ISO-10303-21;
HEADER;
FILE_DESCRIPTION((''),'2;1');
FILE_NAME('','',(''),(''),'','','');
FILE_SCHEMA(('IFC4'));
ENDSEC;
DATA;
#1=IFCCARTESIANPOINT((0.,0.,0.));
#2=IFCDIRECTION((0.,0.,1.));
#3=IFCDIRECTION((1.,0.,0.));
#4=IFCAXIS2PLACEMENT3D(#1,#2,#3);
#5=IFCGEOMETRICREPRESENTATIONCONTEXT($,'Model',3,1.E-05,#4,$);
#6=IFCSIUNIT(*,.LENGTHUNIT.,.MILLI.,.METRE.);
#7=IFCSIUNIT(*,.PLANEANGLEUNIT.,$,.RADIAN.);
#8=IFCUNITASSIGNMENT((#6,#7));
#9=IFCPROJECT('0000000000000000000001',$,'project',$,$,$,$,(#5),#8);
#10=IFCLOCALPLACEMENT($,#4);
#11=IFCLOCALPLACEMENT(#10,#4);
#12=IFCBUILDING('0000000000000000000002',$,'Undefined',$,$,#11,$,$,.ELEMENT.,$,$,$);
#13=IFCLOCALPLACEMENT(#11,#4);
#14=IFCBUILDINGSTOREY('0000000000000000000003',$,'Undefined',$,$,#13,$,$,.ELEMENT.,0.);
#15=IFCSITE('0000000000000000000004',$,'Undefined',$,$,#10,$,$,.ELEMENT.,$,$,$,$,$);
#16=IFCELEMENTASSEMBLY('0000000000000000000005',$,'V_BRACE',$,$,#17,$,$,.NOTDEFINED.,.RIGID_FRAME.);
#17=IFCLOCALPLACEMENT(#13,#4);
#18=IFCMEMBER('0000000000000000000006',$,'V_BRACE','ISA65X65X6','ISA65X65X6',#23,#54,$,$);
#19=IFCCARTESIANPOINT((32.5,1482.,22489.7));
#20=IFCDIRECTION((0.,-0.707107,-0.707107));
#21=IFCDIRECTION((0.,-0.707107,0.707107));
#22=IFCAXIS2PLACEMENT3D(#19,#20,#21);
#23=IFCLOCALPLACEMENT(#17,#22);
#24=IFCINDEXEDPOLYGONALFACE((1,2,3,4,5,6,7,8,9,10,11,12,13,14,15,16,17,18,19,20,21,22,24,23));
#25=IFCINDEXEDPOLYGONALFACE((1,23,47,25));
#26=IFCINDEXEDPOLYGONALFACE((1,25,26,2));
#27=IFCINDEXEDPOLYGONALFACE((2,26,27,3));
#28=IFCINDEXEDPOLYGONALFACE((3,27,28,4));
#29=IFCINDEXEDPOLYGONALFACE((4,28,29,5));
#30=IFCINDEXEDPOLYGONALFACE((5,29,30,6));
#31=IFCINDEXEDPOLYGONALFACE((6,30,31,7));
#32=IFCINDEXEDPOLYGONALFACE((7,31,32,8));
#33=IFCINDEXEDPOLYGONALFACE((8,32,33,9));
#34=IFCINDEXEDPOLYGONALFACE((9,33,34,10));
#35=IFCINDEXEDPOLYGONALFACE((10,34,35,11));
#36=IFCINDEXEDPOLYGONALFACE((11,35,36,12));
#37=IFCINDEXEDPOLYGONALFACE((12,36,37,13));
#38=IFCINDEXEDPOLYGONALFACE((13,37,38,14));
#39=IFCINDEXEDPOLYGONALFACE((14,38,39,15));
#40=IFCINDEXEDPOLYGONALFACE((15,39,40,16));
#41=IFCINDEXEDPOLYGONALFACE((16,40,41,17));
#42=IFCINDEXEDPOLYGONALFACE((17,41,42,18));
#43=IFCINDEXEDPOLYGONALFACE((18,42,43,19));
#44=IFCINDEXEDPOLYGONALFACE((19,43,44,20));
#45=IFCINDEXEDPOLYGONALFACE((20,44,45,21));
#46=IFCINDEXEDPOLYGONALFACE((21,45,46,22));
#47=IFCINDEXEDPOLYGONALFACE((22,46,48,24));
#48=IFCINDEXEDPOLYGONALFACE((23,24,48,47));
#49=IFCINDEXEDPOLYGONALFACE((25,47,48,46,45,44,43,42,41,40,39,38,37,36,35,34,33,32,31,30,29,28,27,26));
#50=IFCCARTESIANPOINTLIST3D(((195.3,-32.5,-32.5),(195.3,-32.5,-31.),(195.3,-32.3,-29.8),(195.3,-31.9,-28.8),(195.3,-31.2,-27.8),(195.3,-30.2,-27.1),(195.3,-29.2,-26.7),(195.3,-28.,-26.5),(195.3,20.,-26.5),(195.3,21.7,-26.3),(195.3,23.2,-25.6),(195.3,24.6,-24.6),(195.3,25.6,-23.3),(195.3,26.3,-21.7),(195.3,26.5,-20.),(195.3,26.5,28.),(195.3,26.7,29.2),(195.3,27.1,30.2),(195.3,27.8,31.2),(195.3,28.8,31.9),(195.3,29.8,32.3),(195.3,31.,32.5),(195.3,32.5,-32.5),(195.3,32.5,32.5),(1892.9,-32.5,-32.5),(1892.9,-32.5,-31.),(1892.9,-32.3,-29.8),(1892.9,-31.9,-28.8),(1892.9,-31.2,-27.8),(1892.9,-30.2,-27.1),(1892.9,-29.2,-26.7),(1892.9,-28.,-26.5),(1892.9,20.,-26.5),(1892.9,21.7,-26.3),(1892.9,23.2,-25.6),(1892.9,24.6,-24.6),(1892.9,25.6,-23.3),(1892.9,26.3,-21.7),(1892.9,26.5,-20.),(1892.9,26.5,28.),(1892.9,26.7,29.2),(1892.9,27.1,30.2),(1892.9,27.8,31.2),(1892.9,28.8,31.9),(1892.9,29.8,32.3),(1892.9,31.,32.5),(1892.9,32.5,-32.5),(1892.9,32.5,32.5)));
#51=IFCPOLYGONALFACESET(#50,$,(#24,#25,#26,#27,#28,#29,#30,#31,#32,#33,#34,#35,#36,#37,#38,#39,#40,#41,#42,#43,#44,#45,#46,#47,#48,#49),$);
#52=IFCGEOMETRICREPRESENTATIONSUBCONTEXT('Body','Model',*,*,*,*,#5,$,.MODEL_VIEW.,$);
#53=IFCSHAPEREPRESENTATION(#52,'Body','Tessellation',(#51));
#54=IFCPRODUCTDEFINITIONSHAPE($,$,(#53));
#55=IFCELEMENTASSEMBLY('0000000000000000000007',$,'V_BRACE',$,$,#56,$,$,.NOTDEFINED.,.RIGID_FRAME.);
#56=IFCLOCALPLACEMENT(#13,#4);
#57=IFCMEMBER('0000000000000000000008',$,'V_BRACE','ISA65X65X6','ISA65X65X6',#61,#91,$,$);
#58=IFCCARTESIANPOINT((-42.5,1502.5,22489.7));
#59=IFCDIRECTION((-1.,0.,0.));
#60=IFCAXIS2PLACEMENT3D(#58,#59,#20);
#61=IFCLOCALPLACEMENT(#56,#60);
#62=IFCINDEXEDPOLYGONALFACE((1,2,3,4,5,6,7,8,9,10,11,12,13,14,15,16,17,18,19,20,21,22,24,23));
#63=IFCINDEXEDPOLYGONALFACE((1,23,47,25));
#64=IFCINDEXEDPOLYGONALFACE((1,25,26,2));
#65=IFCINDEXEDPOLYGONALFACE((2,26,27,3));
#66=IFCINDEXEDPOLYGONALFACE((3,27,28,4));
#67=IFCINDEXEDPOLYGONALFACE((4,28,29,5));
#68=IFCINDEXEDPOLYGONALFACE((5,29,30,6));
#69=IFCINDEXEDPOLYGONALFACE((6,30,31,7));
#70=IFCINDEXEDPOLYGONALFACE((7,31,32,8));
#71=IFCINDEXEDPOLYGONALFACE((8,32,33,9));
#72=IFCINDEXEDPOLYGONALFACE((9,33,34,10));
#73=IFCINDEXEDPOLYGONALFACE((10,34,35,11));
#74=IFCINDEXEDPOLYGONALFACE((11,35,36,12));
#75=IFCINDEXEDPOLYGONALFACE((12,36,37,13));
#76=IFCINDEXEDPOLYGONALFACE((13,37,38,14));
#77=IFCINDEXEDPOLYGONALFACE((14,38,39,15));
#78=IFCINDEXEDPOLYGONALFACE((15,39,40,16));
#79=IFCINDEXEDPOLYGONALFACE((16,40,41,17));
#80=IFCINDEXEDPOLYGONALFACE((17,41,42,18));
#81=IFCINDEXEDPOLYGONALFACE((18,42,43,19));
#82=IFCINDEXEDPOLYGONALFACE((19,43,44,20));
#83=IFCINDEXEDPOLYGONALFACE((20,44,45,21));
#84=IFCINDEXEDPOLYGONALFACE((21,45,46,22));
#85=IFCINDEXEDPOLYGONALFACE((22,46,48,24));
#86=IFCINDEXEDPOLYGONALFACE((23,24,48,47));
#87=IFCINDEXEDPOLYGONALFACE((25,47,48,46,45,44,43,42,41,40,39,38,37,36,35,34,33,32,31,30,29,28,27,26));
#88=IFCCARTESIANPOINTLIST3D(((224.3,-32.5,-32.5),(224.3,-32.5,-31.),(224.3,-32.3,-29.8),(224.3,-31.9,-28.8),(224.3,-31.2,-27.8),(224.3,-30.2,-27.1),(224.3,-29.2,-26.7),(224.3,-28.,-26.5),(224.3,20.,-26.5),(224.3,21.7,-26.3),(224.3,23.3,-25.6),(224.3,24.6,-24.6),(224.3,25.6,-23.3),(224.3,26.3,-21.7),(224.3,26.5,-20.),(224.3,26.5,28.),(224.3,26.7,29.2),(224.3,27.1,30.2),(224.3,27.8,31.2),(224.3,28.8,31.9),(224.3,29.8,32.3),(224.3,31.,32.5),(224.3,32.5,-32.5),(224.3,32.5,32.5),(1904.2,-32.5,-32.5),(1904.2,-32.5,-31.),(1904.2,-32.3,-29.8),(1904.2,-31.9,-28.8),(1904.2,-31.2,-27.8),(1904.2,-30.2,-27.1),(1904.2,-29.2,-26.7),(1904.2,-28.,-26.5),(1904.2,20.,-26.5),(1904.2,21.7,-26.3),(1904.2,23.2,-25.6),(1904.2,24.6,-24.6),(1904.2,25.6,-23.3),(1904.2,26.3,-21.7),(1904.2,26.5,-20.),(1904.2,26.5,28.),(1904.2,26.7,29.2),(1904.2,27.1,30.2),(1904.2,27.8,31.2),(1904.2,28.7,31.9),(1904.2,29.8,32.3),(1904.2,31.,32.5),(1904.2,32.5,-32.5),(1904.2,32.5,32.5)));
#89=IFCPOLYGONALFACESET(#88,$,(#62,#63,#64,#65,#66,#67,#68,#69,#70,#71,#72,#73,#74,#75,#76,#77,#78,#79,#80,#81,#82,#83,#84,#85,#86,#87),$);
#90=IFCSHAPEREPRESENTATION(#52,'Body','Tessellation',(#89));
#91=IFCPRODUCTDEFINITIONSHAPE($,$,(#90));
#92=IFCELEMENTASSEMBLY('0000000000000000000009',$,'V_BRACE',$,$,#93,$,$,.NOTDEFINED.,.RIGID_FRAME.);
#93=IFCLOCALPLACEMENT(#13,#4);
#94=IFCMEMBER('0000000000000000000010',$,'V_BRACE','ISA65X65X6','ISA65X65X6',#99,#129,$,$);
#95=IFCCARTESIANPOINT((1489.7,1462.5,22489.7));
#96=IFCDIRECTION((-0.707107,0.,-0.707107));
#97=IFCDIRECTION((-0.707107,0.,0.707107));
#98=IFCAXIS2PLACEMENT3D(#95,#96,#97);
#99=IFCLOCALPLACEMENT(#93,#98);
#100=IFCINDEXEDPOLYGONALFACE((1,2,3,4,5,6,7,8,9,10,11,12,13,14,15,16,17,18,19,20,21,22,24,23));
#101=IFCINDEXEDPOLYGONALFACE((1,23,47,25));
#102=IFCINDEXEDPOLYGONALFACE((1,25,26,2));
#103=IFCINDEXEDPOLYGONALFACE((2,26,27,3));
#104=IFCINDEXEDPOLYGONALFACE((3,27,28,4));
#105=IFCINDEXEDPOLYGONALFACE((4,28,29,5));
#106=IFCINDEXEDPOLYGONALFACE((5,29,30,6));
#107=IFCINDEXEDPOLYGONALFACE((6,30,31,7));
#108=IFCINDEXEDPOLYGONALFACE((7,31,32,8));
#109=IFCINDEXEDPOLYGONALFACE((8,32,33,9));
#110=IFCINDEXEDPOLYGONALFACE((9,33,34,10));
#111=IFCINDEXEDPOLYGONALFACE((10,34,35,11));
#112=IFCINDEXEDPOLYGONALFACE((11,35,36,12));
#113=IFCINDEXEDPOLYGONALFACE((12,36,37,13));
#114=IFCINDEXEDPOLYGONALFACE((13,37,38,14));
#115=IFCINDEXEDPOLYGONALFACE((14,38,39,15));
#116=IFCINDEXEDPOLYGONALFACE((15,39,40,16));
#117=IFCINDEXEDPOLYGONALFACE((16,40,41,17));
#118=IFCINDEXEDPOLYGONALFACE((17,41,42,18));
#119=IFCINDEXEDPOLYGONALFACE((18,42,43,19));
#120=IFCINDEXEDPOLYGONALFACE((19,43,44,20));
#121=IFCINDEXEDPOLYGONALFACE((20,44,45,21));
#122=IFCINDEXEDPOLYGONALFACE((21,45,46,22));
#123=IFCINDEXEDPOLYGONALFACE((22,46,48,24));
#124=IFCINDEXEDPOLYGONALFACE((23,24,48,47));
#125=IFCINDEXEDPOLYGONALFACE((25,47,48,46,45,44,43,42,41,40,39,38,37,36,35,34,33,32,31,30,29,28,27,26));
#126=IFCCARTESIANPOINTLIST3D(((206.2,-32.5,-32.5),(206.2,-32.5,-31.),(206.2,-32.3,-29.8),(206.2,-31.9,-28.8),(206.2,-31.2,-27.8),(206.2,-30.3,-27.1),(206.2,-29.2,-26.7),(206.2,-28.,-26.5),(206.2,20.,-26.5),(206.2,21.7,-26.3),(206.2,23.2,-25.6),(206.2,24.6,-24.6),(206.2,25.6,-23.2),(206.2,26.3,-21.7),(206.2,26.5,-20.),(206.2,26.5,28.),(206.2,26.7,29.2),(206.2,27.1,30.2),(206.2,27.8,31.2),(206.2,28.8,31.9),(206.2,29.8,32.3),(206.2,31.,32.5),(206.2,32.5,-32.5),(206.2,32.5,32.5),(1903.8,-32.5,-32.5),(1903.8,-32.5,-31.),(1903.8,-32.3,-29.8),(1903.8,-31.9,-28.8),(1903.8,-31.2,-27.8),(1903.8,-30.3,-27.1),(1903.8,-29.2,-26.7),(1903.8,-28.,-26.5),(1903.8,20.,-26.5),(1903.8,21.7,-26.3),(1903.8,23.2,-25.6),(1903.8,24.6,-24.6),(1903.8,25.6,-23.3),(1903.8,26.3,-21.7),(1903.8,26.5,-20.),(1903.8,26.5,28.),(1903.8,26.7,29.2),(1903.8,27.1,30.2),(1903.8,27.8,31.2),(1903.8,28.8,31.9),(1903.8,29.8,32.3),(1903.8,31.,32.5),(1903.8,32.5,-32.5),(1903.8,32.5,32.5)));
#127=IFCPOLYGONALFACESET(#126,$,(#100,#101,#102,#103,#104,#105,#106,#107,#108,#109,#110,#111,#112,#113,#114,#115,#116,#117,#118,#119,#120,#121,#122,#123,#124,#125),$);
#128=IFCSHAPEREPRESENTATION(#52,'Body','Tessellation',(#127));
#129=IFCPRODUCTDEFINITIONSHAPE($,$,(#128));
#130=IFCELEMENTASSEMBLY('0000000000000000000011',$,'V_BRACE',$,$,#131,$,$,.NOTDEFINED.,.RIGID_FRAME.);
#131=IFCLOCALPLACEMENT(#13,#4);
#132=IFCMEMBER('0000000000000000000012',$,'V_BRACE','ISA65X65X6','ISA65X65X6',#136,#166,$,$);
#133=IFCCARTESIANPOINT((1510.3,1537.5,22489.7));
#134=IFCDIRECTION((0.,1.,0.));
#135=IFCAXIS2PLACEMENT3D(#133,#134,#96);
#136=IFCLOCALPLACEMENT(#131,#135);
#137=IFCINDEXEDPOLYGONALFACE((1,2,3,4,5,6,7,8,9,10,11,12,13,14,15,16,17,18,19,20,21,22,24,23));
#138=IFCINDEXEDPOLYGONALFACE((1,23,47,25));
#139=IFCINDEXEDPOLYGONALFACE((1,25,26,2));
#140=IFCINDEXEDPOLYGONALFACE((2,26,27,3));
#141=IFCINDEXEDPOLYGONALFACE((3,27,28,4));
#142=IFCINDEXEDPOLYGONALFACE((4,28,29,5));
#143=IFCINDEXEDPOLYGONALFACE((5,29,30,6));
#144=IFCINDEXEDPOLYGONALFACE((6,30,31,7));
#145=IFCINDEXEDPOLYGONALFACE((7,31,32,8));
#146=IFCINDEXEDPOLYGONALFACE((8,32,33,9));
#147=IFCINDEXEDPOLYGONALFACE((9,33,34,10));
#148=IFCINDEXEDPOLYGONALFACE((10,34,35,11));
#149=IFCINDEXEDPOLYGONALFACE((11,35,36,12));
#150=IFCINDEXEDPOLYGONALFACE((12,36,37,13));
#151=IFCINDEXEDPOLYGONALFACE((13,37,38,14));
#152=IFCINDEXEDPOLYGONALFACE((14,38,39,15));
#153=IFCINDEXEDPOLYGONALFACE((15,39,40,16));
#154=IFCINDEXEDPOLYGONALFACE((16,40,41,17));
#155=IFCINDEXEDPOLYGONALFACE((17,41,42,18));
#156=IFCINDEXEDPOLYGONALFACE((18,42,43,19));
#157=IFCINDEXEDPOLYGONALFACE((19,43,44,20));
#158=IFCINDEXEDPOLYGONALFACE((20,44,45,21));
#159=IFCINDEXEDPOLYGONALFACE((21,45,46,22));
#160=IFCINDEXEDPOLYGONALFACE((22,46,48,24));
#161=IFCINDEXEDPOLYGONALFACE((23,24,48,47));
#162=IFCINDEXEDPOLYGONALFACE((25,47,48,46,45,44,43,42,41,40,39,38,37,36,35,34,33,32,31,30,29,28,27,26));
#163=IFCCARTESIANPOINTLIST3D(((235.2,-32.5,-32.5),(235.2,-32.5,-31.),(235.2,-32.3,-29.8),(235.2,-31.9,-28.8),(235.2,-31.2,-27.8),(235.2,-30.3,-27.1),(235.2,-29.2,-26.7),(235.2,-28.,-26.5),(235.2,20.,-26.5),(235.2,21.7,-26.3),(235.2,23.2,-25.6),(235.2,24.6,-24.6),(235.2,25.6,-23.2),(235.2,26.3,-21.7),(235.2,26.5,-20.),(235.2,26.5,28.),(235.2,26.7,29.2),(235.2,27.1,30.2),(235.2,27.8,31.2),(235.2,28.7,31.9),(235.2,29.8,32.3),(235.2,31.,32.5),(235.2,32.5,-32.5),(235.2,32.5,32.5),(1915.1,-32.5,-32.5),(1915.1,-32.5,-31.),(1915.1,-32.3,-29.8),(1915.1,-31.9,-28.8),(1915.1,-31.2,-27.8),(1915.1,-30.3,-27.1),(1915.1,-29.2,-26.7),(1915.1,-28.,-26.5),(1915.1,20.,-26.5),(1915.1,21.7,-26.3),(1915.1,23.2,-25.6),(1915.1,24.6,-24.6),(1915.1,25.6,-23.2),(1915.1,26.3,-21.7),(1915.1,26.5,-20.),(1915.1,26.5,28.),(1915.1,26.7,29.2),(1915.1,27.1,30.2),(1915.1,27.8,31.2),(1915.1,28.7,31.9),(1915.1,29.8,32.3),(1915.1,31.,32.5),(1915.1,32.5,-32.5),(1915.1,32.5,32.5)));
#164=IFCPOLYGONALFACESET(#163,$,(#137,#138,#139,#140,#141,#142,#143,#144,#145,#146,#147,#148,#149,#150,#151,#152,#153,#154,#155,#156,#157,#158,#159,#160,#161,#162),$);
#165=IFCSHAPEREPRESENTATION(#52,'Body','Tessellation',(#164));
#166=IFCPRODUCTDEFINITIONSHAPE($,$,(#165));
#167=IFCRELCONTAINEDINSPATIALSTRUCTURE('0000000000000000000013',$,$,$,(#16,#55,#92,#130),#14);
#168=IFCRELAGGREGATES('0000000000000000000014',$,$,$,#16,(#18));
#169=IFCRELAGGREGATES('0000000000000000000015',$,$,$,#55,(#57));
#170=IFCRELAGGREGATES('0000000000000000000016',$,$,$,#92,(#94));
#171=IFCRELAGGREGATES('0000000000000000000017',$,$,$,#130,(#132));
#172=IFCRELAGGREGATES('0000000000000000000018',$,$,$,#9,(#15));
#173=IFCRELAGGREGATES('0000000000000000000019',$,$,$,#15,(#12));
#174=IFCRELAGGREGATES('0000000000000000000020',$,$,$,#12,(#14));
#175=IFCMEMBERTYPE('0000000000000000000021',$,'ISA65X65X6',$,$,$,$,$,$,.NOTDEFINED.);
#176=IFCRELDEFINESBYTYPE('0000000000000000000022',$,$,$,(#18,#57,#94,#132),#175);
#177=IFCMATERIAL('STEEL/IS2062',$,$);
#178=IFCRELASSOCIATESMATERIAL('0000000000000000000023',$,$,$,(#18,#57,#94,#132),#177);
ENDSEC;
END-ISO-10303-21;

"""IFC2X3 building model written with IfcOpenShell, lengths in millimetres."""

from ifc_helpers import new_model, si_unit, frame, origin_with_axes, origin_2d_with_axis, place, context, subcontext, project, spatial, l_section, extrude, clip, halfspace, material, type_object, element, aggregate, save


model = new_model("IFC2X3")

# Units and contexts
model_context = context("Model", 3, precision=1e-05, world=origin_with_axes())
body_context = subcontext(model_context, "Body", "Model", "MODEL_VIEW")
ifc_project = project(units=[si_unit("LENGTHUNIT", "METRE", prefix="MILLI"), si_unit("PLANEANGLEUNIT", "RADIAN")], contexts=[model_context])

# Site, building, storey
site_placement = place(None, origin_with_axes())
site = spatial("IfcSite", under=ifc_project, at=site_placement, Name="Undefined", CompositionType="ELEMENT")
building_placement = place(site_placement, origin_with_axes())
building = spatial("IfcBuilding", under=site, at=building_placement, Name="Undefined", CompositionType="ELEMENT")
storey_placement = place(building_placement, origin_with_axes())
storey = spatial("IfcBuildingStorey", under=building, at=storey_placement, Name="Undefined", CompositionType="ELEMENT", Elevation=0.0)

# Shared definitions
ifc_material = material(Name="STEEL/IS2062")

# Element assemblies, members
assembly_1_placement = place(storey_placement, origin_with_axes())
assembly_1 = element("IfcElementAssembly", 1, at=assembly_1_placement, inside=storey, Name="V_BRACE", AssemblyPlace="NOTDEFINED", PredefinedType="RIGID_FRAME")
member_type = type_object("IfcMemberType", Name="ISA65X65X6", PredefinedType="NOTDEFINED")
member_1_placement = place(assembly_1_placement, frame((32.5, 1482.0, 22489.7), z_axis=(0.0, -0.707107, -0.707107), x_axis=(0.0, -0.707107, 0.707107)))
member_1 = element("IfcMember", 2, at=member_1_placement, type_object=member_type, material=ifc_material, Name="V_BRACE", Description="ISA65X65X6", ObjectType="ISA65X65X6", context=body_context, shape_type="Clipping", body=[
    clip(clip(extrude(l_section(Depth=65.0, Width=65.0, Thickness=6.0, FilletRadius=6.5, EdgeRadius=4.5, at=origin_2d_with_axis()), frame((2121.3, 0.0, 0.0), z_axis=(-1.0, 0.0, 0.0), x_axis=(0.0, -1.0, 0.0)), (0.0, 0.0, 1.0), 2121.3), halfspace(frame((1892.9, 42.5, 0.0), z_axis=(-1.0, 0.0, 0.0), x_axis=(0.0, 0.0, 1.0)), True)), halfspace(frame((195.3, 42.5, 0.0), z_axis=(1.0, 0.0, 0.0), x_axis=(0.0, 0.0, -1.0)), True)),
])
aggregate(assembly_1, [member_1])
assembly_2_placement = place(storey_placement, origin_with_axes())
assembly_2 = element("IfcElementAssembly", 3, at=assembly_2_placement, inside=storey, Name="V_BRACE", AssemblyPlace="NOTDEFINED", PredefinedType="RIGID_FRAME")
member_2_placement = place(assembly_2_placement, frame((-42.5, 1502.5, 22489.7), z_axis=(-1.0, 0.0, 0.0), x_axis=(0.0, -0.707107, -0.707107)))
member_2 = element("IfcMember", 4, at=member_2_placement, type_object=member_type, material=ifc_material, Name="V_BRACE", Description="ISA65X65X6", ObjectType="ISA65X65X6", context=body_context, shape_type="Clipping", body=[
    clip(clip(extrude(l_section(Depth=65.0, Width=65.0, Thickness=6.0, FilletRadius=6.5, EdgeRadius=4.5, at=origin_2d_with_axis()), frame((2121.3, 0.0, 0.0), z_axis=(-1.0, 0.0, 0.0), x_axis=(0.0, -1.0, 0.0)), (0.0, 0.0, 1.0), 2121.3), halfspace(frame((1904.2, 0.0, -32.5), z_axis=(-1.0, 0.0, 0.0), x_axis=(0.0, -1.0, 0.0)), True)), halfspace(frame((224.3, 0.0, -32.5), z_axis=(1.0, 0.0, 0.0), x_axis=(0.0, 1.0, 0.0)), True)),
])
aggregate(assembly_2, [member_2])
assembly_3_placement = place(storey_placement, origin_with_axes())
assembly_3 = element("IfcElementAssembly", 5, at=assembly_3_placement, inside=storey, Name="V_BRACE", AssemblyPlace="NOTDEFINED", PredefinedType="RIGID_FRAME")
member_3_placement = place(assembly_3_placement, frame((1489.7, 1462.5, 22489.7), z_axis=(-0.707107, 0.0, -0.707107), x_axis=(-0.707107, 0.0, 0.707107)))
member_3 = element("IfcMember", 6, at=member_3_placement, type_object=member_type, material=ifc_material, Name="V_BRACE", Description="ISA65X65X6", ObjectType="ISA65X65X6", context=body_context, shape_type="Clipping", body=[
    clip(clip(extrude(l_section(Depth=65.0, Width=65.0, Thickness=6.0, FilletRadius=6.5, EdgeRadius=4.5, at=origin_2d_with_axis()), frame((2121.3, 0.0, 0.0), z_axis=(-1.0, 0.0, 0.0), x_axis=(0.0, -1.0, 0.0)), (0.0, 0.0, 1.0), 2121.3), halfspace(frame((1903.8, 32.5, 0.0), z_axis=(-1.0, 0.0, 0.0), x_axis=(0.0, 0.0, -1.0)), True)), halfspace(frame((206.2, 32.5, 0.0), z_axis=(1.0, 0.0, 0.0), x_axis=(0.0, 0.0, 1.0)), True)),
])
aggregate(assembly_3, [member_3])
assembly_4_placement = place(storey_placement, origin_with_axes())
assembly_4 = element("IfcElementAssembly", 7, at=assembly_4_placement, inside=storey, Name="V_BRACE", AssemblyPlace="NOTDEFINED", PredefinedType="RIGID_FRAME")
member_4_placement = place(assembly_4_placement, frame((1510.3, 1537.5, 22489.7), z_axis=(0.0, 1.0, 0.0), x_axis=(-0.707107, 0.0, -0.707107)))
member_4 = element("IfcMember", 8, at=member_4_placement, type_object=member_type, material=ifc_material, Name="V_BRACE", Description="ISA65X65X6", ObjectType="ISA65X65X6", context=body_context, shape_type="Clipping", body=[
    clip(clip(extrude(l_section(Depth=65.0, Width=65.0, Thickness=6.0, FilletRadius=6.5, EdgeRadius=4.5, at=origin_2d_with_axis()), frame((2121.3, 0.0, 0.0), z_axis=(-1.0, 0.0, 0.0), x_axis=(0.0, -1.0, 0.0)), (0.0, 0.0, 1.0), 2121.3), halfspace(frame((1915.1, 0.0, -42.5), z_axis=(-1.0, 0.0, 0.0), x_axis=(0.0, 1.0, 0.0)), True)), halfspace(frame((235.2, 0.0, -42.5), z_axis=(1.0, 0.0, 0.0), x_axis=(0.0, -1.0, 0.0)), True)),
])
aggregate(assembly_4, [member_4])

save(model, "model.ifc")
